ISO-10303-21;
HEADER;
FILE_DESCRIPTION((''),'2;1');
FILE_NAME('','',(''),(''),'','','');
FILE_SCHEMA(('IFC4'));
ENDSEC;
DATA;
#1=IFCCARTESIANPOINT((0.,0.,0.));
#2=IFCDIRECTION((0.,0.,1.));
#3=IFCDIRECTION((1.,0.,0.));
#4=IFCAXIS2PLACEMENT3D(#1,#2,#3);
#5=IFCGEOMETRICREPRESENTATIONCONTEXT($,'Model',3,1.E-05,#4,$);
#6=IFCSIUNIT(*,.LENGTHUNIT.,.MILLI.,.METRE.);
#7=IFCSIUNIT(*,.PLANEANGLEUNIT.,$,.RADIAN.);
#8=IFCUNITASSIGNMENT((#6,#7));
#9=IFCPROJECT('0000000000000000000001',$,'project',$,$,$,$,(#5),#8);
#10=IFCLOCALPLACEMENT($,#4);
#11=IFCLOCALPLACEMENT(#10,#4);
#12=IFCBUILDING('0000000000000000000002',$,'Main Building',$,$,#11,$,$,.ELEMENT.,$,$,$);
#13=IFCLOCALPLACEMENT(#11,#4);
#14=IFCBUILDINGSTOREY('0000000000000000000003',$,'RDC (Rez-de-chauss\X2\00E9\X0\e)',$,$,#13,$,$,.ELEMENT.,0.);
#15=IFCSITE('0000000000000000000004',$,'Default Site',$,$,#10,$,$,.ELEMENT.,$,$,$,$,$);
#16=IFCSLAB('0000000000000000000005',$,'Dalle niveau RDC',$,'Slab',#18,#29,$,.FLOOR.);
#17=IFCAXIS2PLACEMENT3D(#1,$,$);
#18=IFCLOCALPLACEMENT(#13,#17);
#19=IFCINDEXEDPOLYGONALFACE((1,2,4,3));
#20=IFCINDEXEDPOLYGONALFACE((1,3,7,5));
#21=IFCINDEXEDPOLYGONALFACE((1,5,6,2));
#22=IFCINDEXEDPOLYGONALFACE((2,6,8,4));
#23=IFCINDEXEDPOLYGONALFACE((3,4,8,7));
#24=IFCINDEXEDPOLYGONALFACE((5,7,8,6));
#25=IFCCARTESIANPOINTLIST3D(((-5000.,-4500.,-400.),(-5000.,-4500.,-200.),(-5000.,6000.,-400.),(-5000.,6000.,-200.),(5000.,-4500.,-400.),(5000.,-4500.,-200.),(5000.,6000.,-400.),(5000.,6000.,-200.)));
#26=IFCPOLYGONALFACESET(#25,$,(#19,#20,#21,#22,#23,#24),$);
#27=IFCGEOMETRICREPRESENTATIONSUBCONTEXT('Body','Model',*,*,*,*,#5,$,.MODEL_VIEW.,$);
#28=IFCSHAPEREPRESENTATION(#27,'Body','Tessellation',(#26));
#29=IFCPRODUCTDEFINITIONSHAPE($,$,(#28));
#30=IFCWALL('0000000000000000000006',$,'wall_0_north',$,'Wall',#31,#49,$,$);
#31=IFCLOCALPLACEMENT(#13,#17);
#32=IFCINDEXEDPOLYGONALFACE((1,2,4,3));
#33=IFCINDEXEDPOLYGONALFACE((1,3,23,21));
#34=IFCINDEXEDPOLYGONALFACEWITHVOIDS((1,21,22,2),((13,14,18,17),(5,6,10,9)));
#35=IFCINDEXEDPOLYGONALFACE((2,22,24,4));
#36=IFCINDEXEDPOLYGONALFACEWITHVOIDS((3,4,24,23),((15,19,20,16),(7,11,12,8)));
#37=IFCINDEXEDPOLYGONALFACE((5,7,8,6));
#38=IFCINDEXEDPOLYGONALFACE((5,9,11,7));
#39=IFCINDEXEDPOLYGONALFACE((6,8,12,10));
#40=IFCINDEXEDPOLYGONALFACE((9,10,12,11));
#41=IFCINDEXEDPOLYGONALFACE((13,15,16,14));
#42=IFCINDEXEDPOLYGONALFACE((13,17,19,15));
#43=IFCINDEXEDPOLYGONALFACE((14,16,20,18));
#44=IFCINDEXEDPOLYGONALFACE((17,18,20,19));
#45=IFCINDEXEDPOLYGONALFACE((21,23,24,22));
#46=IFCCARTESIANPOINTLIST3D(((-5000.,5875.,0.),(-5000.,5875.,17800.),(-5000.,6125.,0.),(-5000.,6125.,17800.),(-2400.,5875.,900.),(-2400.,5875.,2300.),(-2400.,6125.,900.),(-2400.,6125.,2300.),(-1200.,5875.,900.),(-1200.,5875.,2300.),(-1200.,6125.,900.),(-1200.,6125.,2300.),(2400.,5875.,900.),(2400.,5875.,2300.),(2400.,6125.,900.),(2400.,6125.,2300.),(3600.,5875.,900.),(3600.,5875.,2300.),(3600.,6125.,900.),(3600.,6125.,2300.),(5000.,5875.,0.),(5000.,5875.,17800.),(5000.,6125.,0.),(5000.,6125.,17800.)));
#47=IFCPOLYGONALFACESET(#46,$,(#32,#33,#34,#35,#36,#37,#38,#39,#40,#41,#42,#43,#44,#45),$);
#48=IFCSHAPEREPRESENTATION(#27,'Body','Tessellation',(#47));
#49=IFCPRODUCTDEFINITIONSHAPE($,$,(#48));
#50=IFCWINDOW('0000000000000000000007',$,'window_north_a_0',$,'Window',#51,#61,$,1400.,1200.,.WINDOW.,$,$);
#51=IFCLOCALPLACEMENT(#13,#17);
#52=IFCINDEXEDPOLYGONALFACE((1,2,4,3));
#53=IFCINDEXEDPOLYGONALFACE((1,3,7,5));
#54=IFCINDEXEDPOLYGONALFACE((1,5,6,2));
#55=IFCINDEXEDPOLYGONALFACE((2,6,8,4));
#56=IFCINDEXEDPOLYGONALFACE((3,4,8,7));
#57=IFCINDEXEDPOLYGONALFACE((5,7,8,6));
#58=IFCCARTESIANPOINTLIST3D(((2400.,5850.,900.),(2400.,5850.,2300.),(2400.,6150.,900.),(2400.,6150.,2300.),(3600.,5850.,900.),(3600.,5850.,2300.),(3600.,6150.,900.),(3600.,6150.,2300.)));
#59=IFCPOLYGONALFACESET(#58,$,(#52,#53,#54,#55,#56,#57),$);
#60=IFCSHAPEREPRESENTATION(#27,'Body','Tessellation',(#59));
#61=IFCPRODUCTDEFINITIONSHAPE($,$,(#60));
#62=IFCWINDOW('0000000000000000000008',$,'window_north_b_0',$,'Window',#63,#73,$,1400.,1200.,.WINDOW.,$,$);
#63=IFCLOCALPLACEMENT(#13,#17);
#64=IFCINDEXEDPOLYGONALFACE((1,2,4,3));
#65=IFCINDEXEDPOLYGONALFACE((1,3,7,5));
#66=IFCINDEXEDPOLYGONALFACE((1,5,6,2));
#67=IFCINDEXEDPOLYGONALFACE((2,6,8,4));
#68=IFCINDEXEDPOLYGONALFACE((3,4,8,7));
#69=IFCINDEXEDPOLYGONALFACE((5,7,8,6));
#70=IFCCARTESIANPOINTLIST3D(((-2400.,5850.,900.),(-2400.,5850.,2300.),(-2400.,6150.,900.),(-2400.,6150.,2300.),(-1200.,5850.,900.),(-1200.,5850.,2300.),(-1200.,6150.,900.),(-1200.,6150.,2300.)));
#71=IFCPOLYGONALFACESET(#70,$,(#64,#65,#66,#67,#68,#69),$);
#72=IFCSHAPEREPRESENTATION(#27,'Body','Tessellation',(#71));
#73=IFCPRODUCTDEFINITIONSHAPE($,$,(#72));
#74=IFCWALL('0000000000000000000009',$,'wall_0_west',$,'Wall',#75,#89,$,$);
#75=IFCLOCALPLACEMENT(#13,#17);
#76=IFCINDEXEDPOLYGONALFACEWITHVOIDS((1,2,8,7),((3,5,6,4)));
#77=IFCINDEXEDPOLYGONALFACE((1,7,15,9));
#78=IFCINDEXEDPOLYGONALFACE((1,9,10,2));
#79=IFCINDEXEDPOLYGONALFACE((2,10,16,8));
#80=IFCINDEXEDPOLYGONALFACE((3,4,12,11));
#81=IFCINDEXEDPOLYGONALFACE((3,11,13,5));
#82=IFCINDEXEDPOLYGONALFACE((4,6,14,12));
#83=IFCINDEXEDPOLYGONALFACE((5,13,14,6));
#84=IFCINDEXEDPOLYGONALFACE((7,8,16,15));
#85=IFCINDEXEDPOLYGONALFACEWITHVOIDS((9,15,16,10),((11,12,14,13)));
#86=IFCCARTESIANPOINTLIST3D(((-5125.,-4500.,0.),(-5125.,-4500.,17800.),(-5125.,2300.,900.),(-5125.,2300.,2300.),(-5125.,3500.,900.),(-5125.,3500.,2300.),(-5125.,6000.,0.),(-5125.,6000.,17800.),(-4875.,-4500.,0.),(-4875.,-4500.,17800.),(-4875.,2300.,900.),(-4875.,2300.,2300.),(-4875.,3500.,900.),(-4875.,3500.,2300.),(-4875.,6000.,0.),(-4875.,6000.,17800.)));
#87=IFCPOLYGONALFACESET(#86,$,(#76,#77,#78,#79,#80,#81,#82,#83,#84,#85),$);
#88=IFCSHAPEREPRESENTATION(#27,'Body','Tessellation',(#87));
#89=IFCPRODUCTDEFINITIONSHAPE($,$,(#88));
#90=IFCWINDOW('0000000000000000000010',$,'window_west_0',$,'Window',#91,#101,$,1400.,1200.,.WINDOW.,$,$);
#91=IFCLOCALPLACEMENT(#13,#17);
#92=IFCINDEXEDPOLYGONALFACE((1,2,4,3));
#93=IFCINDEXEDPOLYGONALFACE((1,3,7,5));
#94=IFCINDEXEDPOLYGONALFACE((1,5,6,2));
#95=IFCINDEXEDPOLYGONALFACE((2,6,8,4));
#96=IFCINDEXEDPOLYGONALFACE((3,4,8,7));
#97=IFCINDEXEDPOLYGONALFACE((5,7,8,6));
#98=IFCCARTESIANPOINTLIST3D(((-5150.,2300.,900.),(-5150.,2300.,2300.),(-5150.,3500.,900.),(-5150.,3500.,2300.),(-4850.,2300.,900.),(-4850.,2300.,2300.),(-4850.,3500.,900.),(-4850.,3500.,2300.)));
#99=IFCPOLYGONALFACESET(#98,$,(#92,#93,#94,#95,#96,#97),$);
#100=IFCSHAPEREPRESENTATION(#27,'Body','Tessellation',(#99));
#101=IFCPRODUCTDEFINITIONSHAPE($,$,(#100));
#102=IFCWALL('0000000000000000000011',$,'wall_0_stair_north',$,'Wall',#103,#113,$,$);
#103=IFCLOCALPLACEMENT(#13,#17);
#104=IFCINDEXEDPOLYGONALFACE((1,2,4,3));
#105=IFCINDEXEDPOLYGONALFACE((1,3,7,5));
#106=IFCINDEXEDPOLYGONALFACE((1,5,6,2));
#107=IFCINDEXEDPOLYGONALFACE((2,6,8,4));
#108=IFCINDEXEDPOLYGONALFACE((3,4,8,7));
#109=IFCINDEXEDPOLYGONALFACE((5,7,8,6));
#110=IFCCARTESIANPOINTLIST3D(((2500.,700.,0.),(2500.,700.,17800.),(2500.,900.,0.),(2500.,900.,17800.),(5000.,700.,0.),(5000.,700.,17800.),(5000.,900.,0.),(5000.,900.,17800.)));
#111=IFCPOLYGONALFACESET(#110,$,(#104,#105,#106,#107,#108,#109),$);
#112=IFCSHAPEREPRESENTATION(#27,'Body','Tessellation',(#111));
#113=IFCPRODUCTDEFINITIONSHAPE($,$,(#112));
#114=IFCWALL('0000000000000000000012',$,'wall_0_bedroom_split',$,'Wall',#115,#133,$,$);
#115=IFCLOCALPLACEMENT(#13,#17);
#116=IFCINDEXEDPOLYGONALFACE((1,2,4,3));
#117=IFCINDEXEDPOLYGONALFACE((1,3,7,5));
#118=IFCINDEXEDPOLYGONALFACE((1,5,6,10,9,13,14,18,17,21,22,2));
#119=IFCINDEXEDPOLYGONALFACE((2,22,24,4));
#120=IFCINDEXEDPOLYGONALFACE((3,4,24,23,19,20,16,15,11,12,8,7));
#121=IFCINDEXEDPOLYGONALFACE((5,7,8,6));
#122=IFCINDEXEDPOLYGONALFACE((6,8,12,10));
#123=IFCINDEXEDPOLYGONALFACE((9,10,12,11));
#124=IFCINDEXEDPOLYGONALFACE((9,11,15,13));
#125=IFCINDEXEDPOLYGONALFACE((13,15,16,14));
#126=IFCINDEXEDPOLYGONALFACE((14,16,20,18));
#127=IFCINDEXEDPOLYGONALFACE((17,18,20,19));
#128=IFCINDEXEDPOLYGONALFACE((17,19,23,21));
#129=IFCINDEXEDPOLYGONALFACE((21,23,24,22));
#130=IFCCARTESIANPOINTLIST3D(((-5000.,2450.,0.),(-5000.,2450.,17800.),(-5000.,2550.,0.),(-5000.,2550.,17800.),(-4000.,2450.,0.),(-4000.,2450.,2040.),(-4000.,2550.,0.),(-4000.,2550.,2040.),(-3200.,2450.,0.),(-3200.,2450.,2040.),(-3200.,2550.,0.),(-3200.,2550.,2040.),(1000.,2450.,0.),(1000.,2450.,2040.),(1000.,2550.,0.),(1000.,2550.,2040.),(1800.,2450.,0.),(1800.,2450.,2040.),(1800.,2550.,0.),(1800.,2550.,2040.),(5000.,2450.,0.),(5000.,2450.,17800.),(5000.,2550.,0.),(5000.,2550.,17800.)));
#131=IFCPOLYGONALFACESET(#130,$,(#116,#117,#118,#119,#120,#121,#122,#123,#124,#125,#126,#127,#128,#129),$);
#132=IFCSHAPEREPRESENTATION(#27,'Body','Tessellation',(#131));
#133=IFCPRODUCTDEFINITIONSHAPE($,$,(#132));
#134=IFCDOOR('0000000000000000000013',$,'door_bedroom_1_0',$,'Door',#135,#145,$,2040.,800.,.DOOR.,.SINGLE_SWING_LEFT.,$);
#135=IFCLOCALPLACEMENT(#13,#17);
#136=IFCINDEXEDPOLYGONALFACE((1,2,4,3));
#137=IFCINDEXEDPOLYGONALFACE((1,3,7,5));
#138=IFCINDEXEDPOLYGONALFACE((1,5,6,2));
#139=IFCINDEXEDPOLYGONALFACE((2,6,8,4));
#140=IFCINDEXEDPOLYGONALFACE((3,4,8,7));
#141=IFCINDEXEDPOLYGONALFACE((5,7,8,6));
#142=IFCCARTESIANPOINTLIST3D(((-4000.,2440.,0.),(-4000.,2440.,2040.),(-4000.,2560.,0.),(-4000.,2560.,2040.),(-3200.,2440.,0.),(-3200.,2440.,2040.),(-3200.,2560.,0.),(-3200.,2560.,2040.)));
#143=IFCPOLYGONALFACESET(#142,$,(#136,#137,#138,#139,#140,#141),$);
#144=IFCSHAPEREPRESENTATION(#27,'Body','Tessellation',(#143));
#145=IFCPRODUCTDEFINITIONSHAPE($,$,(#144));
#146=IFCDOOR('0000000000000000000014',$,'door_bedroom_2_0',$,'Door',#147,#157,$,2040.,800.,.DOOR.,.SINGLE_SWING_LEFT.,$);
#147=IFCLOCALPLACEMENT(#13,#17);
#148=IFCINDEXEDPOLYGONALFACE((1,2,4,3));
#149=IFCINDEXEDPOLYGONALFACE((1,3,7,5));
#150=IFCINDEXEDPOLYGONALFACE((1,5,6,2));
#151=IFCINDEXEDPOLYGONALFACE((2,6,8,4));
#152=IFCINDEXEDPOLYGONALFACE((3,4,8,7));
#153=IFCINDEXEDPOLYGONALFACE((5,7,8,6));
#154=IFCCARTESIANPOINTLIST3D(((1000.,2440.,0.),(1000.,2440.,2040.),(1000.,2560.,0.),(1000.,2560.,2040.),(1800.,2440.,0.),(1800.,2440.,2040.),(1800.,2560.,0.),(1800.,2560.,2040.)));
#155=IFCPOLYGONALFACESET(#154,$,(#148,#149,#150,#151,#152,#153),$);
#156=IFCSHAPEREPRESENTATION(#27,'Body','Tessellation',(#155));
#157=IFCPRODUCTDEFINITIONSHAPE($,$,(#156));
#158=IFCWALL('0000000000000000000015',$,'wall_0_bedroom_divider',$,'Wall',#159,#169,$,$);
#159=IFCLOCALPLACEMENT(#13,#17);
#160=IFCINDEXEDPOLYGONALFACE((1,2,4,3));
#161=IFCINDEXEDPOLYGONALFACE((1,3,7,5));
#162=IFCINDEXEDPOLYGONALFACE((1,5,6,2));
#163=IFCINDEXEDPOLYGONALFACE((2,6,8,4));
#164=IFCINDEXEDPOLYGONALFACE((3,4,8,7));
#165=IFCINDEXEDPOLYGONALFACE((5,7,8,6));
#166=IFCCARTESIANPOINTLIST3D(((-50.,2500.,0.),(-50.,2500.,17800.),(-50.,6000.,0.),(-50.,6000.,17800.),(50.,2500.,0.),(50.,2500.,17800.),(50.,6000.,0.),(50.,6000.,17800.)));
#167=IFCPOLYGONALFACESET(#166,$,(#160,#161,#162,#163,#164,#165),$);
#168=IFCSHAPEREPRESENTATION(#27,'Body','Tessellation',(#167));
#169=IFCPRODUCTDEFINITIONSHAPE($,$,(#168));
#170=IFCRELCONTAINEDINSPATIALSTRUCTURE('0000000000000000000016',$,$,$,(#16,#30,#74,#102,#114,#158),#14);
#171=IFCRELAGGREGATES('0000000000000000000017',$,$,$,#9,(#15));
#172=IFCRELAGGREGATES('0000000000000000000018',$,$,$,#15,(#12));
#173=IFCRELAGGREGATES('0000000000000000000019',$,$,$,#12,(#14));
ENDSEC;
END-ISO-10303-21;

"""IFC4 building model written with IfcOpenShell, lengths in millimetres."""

from ifc_helpers import new_model, si_unit, frame, origin_with_axes, place, context, subcontext, project, spatial, polyline, outline, extrude, element, fill, save


model = new_model("IFC4")

# Units and contexts
model_context = context("Model", 3, precision=1e-05, world=origin_with_axes())
body_context = subcontext(model_context, "Body", "Model", "MODEL_VIEW")
ifc_project = project(units=[si_unit("LENGTHUNIT", "METRE", prefix="MILLI"), si_unit("PLANEANGLEUNIT", "RADIAN")], contexts=[model_context])

# Site, building, storey
site_placement = place(None, origin_with_axes())
site = spatial("IfcSite", under=ifc_project, at=site_placement, Name="Default Site", CompositionType="ELEMENT")
building_placement = place(site_placement, origin_with_axes())
building = spatial("IfcBuilding", under=site, at=building_placement, Name="Main Building", CompositionType="ELEMENT")
storey_placement = place(building_placement, origin_with_axes())
storey = spatial("IfcBuildingStorey", under=building, at=storey_placement, Name="RDC (Rez-de-chaussée)", CompositionType="ELEMENT", Elevation=0.0)

# Slab
slab_placement = place(storey_placement, frame((0.0, 0.0, -400.0), z_axis=(0.0, 0.0, 1.0), x_axis=(1.0, 0.0, 0.0)))
element("IfcSlab", 1, at=slab_placement, inside=storey, Name="Dalle niveau RDC", ObjectType="Slab", PredefinedType="FLOOR", context=body_context, shape_type="SweptSolid", body=[
    extrude(outline(polyline([(-5000.0, -4500.0), (5000.0, -4500.0), (5000.0, 6000.0), (-5000.0, 6000.0), (-5000.0, -4500.0)])), origin_with_axes(), (0.0, 0.0, 1.0), 200.0),
])

# Wall, openings, windows
wall_1_placement = place(storey_placement, frame((5000.0, 6000.0, 0.0), z_axis=(0.0, 0.0, 1.0), x_axis=(-1.0, 0.0, 0.0)))
wall_1 = element("IfcWall", 2, at=wall_1_placement, inside=storey, Name="wall_0_north", ObjectType="Wall", context=body_context, shape_type="SweptSolid", body=[
    extrude(outline(polyline([(0.0, -125.0), (10000.0, -125.0), (10000.0, 125.0), (0.0, 125.0), (0.0, -125.0)])), origin_with_axes(), (0.0, 0.0, 1.0), 17800.0),
])
placement_1 = place(wall_1_placement, frame((1400.0, 0.0, 900.0), z_axis=(0.0, 0.0, 1.0), x_axis=(1.0, 0.0, 0.0)))
opening_1 = element("IfcOpeningElement", 3, at=placement_1, cuts=wall_1, PredefinedType="OPENING", context=body_context, shape_type="SweptSolid", body=[
    extrude(outline(polyline([(0.0, -150.0), (1200.0, -150.0), (1200.0, 150.0), (0.0, 150.0), (0.0, -150.0)])), origin_with_axes(), (0.0, 0.0, 1.0), 1400.0),
])
placement_2 = place(wall_1_placement, frame((6200.0, 0.0, 900.0), z_axis=(0.0, 0.0, 1.0), x_axis=(1.0, 0.0, 0.0)))
opening_2 = element("IfcOpeningElement", 4, at=placement_2, cuts=wall_1, PredefinedType="OPENING", context=body_context, shape_type="SweptSolid", body=[
    extrude(outline(polyline([(0.0, -150.0), (1200.0, -150.0), (1200.0, 150.0), (0.0, 150.0), (0.0, -150.0)])), origin_with_axes(), (0.0, 0.0, 1.0), 1400.0),
])
window_1 = element("IfcWindow", 5, at=placement_1, Name="window_north_a_0", ObjectType="Window", OverallHeight=1400.0, OverallWidth=1200.0, PredefinedType="WINDOW", context=body_context, shape_type="SweptSolid", body=[
    extrude(outline(polyline([(0.0, -150.0), (1200.0, -150.0), (1200.0, 150.0), (0.0, 150.0), (0.0, -150.0)])), origin_with_axes(), (0.0, 0.0, 1.0), 1400.0),
])
fill(opening_1, window_1)
window_2 = element("IfcWindow", 6, at=placement_2, Name="window_north_b_0", ObjectType="Window", OverallHeight=1400.0, OverallWidth=1200.0, PredefinedType="WINDOW", context=body_context, shape_type="SweptSolid", body=[
    extrude(outline(polyline([(0.0, -150.0), (1200.0, -150.0), (1200.0, 150.0), (0.0, 150.0), (0.0, -150.0)])), origin_with_axes(), (0.0, 0.0, 1.0), 1400.0),
])
fill(opening_2, window_2)

# Wall, opening, window
wall_2_placement = place(storey_placement, frame((-5000.0, 6000.0, 0.0), z_axis=(0.0, 0.0, 1.0), x_axis=(0.0, -1.0, 0.0)))
wall_2 = element("IfcWall", 7, at=wall_2_placement, inside=storey, Name="wall_0_west", ObjectType="Wall", context=body_context, shape_type="SweptSolid", body=[
    extrude(outline(polyline([(0.0, -125.0), (10500.0, -125.0), (10500.0, 125.0), (0.0, 125.0), (0.0, -125.0)])), origin_with_axes(), (0.0, 0.0, 1.0), 17800.0),
])
placement_3 = place(wall_2_placement, frame((2500.0, 0.0, 900.0), z_axis=(0.0, 0.0, 1.0), x_axis=(1.0, 0.0, 0.0)))
opening_3 = element("IfcOpeningElement", 8, at=placement_3, cuts=wall_2, PredefinedType="OPENING", context=body_context, shape_type="SweptSolid", body=[
    extrude(outline(polyline([(0.0, -150.0), (1200.0, -150.0), (1200.0, 150.0), (0.0, 150.0), (0.0, -150.0)])), origin_with_axes(), (0.0, 0.0, 1.0), 1400.0),
])
window_3 = element("IfcWindow", 9, at=placement_3, Name="window_west_0", ObjectType="Window", OverallHeight=1400.0, OverallWidth=1200.0, PredefinedType="WINDOW", context=body_context, shape_type="SweptSolid", body=[
    extrude(outline(polyline([(0.0, -150.0), (1200.0, -150.0), (1200.0, 150.0), (0.0, 150.0), (0.0, -150.0)])), origin_with_axes(), (0.0, 0.0, 1.0), 1400.0),
])
fill(opening_3, window_3)

# Wall
wall_3_placement = place(storey_placement, frame((2500.0, 800.0, 0.0), z_axis=(0.0, 0.0, 1.0), x_axis=(1.0, 0.0, 0.0)))
element("IfcWall", 10, at=wall_3_placement, inside=storey, Name="wall_0_stair_north", ObjectType="Wall", context=body_context, shape_type="SweptSolid", body=[
    extrude(outline(polyline([(0.0, -100.0), (2500.0, -100.0), (2500.0, 100.0), (0.0, 100.0), (0.0, -100.0)])), origin_with_axes(), (0.0, 0.0, 1.0), 17800.0),
])

# Wall, openings, doors
wall_4_placement = place(storey_placement, frame((-5000.0, 2500.0, 0.0), z_axis=(0.0, 0.0, 1.0), x_axis=(1.0, 0.0, 0.0)))
wall_4 = element("IfcWall", 11, at=wall_4_placement, inside=storey, Name="wall_0_bedroom_split", ObjectType="Wall", context=body_context, shape_type="SweptSolid", body=[
    extrude(outline(polyline([(0.0, -50.0), (10000.0, -50.0), (10000.0, 50.0), (0.0, 50.0), (0.0, -50.0)])), origin_with_axes(), (0.0, 0.0, 1.0), 17800.0),
])
placement_4 = place(wall_4_placement, frame((1000.0, 0.0, 0.0), z_axis=(0.0, 0.0, 1.0), x_axis=(1.0, 0.0, 0.0)))
opening_4 = element("IfcOpeningElement", 12, at=placement_4, cuts=wall_4, PredefinedType="OPENING", context=body_context, shape_type="SweptSolid", body=[
    extrude(outline(polyline([(0.0, -60.0), (800.0, -60.0), (800.0, 60.0), (0.0, 60.0), (0.0, -60.0)])), origin_with_axes(), (0.0, 0.0, 1.0), 2040.0),
])
placement_5 = place(wall_4_placement, frame((6000.0, 0.0, 0.0), z_axis=(0.0, 0.0, 1.0), x_axis=(1.0, 0.0, 0.0)))
opening_5 = element("IfcOpeningElement", 13, at=placement_5, cuts=wall_4, PredefinedType="OPENING", context=body_context, shape_type="SweptSolid", body=[
    extrude(outline(polyline([(0.0, -60.0), (800.0, -60.0), (800.0, 60.0), (0.0, 60.0), (0.0, -60.0)])), origin_with_axes(), (0.0, 0.0, 1.0), 2040.0),
])
door_1 = element("IfcDoor", 14, at=placement_4, Name="door_bedroom_1_0", ObjectType="Door", OperationType="SINGLE_SWING_LEFT", OverallHeight=2040.0, OverallWidth=800.0, PredefinedType="DOOR", context=body_context, shape_type="SweptSolid", body=[
    extrude(outline(polyline([(0.0, -60.0), (800.0, -60.0), (800.0, 60.0), (0.0, 60.0), (0.0, -60.0)])), origin_with_axes(), (0.0, 0.0, 1.0), 2040.0),
])
fill(opening_4, door_1)
door_2 = element("IfcDoor", 15, at=placement_5, Name="door_bedroom_2_0", ObjectType="Door", OperationType="SINGLE_SWING_LEFT", OverallHeight=2040.0, OverallWidth=800.0, PredefinedType="DOOR", context=body_context, shape_type="SweptSolid", body=[
    extrude(outline(polyline([(0.0, -60.0), (800.0, -60.0), (800.0, 60.0), (0.0, 60.0), (0.0, -60.0)])), origin_with_axes(), (0.0, 0.0, 1.0), 2040.0),
])
fill(opening_5, door_2)

# Wall
wall_5_placement = place(storey_placement, frame((0.0, 2500.0, 0.0), z_axis=(0.0, 0.0, 1.0), x_axis=(0.0, 1.0, 0.0)))
element("IfcWall", 16, at=wall_5_placement, inside=storey, Name="wall_0_bedroom_divider", ObjectType="Wall", context=body_context, shape_type="SweptSolid", body=[
    extrude(outline(polyline([(0.0, -50.0), (3500.0, -50.0), (3500.0, 50.0), (0.0, 50.0), (0.0, -50.0)])), origin_with_axes(), (0.0, 0.0, 1.0), 17800.0),
])

save(model, "model.ifc")
